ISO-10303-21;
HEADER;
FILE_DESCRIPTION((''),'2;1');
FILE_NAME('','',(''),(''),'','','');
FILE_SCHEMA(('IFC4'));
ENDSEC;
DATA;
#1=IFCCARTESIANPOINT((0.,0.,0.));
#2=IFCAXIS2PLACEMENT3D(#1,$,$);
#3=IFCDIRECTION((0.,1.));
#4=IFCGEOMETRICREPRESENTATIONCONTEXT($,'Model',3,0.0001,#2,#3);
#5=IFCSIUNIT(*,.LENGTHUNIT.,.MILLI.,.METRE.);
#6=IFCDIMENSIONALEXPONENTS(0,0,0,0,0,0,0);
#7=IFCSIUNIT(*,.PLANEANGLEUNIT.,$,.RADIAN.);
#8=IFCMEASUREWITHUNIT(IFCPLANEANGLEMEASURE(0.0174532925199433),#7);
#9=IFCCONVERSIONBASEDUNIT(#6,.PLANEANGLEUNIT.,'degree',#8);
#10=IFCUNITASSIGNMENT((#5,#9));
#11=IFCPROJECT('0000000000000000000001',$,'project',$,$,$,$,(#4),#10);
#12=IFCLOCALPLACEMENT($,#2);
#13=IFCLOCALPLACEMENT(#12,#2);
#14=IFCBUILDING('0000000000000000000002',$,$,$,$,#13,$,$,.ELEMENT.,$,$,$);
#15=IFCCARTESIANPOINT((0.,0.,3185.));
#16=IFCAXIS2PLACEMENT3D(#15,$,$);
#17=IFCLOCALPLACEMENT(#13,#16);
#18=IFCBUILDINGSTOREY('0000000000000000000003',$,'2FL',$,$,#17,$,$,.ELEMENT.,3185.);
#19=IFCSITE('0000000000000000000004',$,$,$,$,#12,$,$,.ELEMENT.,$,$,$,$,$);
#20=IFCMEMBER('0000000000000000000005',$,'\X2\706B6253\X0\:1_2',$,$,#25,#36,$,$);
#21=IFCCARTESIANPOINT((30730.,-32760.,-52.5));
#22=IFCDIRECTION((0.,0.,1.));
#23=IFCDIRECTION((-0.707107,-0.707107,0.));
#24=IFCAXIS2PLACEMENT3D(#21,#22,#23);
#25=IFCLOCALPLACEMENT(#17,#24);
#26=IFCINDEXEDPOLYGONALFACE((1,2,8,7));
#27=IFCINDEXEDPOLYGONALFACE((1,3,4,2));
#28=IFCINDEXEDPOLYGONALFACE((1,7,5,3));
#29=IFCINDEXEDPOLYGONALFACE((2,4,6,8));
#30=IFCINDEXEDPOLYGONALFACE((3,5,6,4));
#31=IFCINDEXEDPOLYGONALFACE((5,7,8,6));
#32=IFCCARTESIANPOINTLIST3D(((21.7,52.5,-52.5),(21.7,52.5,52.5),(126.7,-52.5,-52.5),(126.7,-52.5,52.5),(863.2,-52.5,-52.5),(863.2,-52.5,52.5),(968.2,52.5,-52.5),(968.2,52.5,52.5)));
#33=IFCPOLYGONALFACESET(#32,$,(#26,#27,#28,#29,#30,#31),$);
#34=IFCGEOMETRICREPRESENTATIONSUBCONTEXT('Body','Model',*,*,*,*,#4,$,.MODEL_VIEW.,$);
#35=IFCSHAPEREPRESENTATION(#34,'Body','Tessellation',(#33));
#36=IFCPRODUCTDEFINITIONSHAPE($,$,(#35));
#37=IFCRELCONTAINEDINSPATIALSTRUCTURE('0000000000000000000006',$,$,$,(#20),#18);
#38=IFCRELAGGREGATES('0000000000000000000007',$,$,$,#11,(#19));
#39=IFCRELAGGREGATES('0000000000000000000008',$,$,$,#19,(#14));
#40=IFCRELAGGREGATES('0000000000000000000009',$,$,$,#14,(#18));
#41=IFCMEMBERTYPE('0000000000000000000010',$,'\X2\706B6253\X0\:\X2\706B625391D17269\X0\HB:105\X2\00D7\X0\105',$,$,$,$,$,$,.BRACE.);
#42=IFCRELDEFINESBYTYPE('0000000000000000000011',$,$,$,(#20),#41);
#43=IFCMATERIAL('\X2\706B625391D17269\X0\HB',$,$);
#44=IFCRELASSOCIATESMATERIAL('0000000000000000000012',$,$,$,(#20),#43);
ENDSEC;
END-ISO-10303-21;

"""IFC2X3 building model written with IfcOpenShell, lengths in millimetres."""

from ifc_helpers import new_model, entity, si_unit, converted_unit, direction, frame, origin, place, context, subcontext, project, spatial, polyline, outline, extrude, material, type_object, element, save


model = new_model("IFC2X3")

# Units and contexts
model_context = context("Model", 3, precision=0.0001, world=origin(), true_north=direction((0.0, 1.0)))
body_context = subcontext(model_context, "Body", "Model", "MODEL_VIEW")
ifc_project = project(units=[si_unit("LENGTHUNIT", "METRE", prefix="MILLI"), converted_unit("PLANEANGLEUNIT", "degree", entity("IfcPlaneAngleMeasure", 0.0174532925199433), si_unit("PLANEANGLEUNIT", "RADIAN"), dimensions=[0, 0, 0, 0, 0, 0, 0])], contexts=[model_context])

# Site, building, storey
site_placement = place(None, origin())
site = spatial("IfcSite", under=ifc_project, at=site_placement, CompositionType="ELEMENT")
building_placement = place(site_placement, origin())
building = spatial("IfcBuilding", under=site, at=building_placement, CompositionType="ELEMENT")
storey_placement = place(building_placement, frame((0.0, 0.0, 3185.0)))
storey = spatial("IfcBuildingStorey", under=building, at=storey_placement, Name="2FL", CompositionType="ELEMENT", Elevation=3185.0)

# Member
ifc_material = material(Name="火打金物HB")
member_type = type_object("IfcMemberType", Name="火打:火打金物HB:105×105", PredefinedType="BRACE")
member_placement = place(storey_placement, frame((30730.0, -32760.0, -52.5), z_axis=(0.0, 0.0, 1.0), x_axis=(-0.707107, -0.707107, 0.0)))
element("IfcMember", 1, at=member_placement, inside=storey, type_object=member_type, material=ifc_material, Name="火打:1_2", context=body_context, shape_type="SweptSolid", body=[
    extrude(outline(polyline([(126.7, -52.5, 0.0), (21.7, 52.5, 0.0), (968.2, 52.5, 0.0), (863.2, -52.5, 0.0), (126.7, -52.5, 0.0)])), frame((0.0, 0.0, -52.5), z_axis=(0.0, 0.0, 1.0), x_axis=(1.0, 0.0, 0.0)), (0.0, 0.0, 1.0), 105.0),
])

save(model, "model.ifc")
